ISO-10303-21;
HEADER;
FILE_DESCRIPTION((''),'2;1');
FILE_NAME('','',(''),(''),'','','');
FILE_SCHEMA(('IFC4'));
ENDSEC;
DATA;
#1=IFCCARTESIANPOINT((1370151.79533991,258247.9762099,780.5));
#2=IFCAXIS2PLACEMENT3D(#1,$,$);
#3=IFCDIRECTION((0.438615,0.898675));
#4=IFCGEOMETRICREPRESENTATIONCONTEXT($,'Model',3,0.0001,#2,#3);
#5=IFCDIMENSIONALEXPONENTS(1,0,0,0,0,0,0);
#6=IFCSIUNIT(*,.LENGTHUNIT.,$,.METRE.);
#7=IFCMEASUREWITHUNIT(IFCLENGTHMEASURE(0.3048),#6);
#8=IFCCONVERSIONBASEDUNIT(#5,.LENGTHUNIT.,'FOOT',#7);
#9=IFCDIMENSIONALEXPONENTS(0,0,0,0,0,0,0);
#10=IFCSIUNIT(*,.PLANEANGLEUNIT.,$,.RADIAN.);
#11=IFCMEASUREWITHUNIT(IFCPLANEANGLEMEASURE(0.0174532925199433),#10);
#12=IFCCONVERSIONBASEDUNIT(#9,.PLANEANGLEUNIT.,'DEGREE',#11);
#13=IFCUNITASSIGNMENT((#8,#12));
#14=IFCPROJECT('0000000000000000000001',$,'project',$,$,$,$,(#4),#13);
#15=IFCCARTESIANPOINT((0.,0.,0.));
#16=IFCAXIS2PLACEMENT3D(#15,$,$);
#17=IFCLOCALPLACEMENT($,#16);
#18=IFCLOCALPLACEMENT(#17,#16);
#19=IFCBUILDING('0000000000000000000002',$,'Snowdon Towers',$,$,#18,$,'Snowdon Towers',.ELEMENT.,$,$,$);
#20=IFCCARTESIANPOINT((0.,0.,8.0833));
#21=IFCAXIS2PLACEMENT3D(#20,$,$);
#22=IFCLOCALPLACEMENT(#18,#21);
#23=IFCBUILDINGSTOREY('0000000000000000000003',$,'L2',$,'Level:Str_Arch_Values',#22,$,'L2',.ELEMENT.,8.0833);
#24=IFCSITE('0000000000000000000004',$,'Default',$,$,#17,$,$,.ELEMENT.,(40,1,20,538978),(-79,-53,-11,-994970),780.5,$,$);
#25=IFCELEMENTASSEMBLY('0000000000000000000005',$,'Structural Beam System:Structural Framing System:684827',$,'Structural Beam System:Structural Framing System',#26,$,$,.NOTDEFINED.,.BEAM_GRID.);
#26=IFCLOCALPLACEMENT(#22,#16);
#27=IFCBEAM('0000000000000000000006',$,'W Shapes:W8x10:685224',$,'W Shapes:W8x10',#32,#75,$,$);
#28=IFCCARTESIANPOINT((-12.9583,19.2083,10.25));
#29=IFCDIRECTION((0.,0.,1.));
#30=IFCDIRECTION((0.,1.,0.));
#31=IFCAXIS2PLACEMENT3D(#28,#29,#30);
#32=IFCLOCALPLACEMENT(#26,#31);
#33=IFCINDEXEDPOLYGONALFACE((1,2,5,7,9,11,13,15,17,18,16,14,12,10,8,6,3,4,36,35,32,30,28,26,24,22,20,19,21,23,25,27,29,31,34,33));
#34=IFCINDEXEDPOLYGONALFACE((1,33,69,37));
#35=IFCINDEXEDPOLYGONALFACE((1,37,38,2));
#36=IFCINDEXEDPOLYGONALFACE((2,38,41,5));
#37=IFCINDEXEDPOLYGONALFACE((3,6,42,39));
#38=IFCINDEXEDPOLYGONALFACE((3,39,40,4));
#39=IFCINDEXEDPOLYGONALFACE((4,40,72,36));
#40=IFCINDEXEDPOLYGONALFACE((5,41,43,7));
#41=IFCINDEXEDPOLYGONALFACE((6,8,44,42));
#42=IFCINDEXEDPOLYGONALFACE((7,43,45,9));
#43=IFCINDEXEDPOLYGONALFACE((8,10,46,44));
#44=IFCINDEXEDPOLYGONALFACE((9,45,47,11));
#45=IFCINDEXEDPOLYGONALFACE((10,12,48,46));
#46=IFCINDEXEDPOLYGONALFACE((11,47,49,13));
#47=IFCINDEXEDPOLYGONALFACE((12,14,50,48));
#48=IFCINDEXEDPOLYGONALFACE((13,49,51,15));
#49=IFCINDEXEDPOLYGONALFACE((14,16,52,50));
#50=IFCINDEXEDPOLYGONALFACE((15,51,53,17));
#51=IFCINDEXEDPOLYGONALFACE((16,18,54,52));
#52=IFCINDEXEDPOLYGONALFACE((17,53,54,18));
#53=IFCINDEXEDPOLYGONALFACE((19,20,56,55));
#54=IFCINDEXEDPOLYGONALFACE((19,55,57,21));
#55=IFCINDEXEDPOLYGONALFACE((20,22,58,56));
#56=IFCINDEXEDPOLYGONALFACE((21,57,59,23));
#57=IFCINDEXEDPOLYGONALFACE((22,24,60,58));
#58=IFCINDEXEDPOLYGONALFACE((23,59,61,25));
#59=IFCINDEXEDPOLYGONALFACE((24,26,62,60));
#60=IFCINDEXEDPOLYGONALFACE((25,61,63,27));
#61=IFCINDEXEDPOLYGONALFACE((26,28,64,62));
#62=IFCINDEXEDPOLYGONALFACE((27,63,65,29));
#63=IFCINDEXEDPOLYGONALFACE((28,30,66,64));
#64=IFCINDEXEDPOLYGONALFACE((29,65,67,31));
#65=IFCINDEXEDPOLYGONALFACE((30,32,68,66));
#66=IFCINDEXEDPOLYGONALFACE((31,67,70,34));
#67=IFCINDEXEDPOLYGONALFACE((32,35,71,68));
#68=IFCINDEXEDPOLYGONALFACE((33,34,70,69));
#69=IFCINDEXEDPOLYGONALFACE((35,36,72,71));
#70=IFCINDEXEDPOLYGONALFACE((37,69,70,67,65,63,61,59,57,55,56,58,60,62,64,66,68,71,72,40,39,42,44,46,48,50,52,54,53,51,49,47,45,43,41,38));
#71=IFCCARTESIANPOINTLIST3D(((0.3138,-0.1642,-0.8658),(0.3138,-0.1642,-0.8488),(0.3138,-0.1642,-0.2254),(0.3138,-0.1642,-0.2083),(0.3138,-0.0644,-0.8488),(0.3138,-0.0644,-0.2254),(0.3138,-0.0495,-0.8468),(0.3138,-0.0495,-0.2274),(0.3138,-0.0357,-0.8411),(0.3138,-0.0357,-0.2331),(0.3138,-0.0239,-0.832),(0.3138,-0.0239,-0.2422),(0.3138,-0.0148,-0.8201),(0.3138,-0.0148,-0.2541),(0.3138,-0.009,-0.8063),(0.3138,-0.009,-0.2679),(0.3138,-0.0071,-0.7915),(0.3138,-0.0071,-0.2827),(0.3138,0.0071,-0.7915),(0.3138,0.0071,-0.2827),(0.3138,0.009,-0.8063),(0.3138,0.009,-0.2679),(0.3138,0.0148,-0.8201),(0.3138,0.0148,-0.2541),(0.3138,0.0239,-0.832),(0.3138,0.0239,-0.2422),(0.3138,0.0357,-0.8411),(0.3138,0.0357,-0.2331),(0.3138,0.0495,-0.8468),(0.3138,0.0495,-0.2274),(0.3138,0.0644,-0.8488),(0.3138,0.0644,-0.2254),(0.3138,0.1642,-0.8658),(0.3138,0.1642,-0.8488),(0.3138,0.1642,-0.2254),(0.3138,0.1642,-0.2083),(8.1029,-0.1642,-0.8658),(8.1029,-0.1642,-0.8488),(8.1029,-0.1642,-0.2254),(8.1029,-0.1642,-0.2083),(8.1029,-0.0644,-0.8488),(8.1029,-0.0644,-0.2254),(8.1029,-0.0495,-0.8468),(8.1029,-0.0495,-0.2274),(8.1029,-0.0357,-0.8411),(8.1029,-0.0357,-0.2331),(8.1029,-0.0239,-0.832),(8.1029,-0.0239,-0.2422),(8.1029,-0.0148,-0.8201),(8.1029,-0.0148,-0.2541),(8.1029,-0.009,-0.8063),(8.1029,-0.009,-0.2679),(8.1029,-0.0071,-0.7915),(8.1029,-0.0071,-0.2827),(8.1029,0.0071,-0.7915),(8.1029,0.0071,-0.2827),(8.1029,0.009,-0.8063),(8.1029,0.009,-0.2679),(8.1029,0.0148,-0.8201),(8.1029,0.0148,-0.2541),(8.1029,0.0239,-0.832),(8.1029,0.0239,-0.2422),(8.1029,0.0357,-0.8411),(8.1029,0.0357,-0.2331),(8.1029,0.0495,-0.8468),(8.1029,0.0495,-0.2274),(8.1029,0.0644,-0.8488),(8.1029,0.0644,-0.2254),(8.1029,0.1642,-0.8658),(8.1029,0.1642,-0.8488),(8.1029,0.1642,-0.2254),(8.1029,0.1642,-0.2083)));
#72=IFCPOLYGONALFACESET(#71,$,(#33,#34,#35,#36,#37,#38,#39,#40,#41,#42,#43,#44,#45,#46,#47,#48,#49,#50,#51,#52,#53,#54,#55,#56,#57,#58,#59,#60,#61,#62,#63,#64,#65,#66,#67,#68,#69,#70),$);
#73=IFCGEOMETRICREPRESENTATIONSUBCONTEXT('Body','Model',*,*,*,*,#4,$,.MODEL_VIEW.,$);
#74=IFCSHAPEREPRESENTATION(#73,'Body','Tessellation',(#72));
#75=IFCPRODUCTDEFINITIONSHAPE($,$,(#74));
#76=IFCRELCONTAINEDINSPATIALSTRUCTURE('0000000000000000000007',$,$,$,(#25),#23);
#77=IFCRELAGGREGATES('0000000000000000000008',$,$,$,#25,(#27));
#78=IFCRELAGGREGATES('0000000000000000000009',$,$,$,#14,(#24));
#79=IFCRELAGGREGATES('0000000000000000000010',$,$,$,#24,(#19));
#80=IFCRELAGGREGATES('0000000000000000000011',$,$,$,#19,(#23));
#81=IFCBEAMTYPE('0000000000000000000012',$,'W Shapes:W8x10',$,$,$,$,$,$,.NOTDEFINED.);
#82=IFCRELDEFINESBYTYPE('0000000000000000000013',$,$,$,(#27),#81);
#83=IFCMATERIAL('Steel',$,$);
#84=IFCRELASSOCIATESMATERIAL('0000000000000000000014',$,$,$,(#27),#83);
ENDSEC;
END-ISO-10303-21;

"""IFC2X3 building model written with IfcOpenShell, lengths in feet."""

from ifc_helpers import new_model, entity, si_unit, converted_unit, direction, frame, frame_2d, origin, place, context, subcontext, project, spatial, i_section, extrude, material, type_object, element, aggregate, save


model = new_model("IFC2X3")

# Units and contexts
model_context = context("Model", 3, precision=0.0001, world=frame((1370151.79533991, 258247.9762099, 780.5)), true_north=direction((0.438615, 0.898675)))
body_context = subcontext(model_context, "Body", "Model", "MODEL_VIEW")
ifc_project = project(units=[converted_unit("LENGTHUNIT", "FOOT", entity("IfcLengthMeasure", 0.3048), si_unit("LENGTHUNIT", "METRE"), dimensions=[1, 0, 0, 0, 0, 0, 0]), converted_unit("PLANEANGLEUNIT", "DEGREE", entity("IfcPlaneAngleMeasure", 0.0174532925199433), si_unit("PLANEANGLEUNIT", "RADIAN"), dimensions=[0, 0, 0, 0, 0, 0, 0])], contexts=[model_context])

# Site, building, storey
site_placement = place(None, origin())
site = spatial("IfcSite", under=ifc_project, at=site_placement, Name="Default", CompositionType="ELEMENT", RefLatitude=(40, 1, 20, 538978), RefLongitude=(-79, -53, -11, -994970), RefElevation=780.5)
building_placement = place(site_placement, origin())
building = spatial("IfcBuilding", under=site, at=building_placement, Name="Snowdon Towers", LongName="Snowdon Towers", CompositionType="ELEMENT")
storey_placement = place(building_placement, frame((0.0, 0.0, 8.0833)))
storey = spatial("IfcBuildingStorey", under=building, at=storey_placement, Name="L2", ObjectType="Level:Str_Arch_Values", LongName="L2", CompositionType="ELEMENT", Elevation=8.0833)

# Shared definitions
ifc_material_1 = material(Name="Steel")

# Element assembly, beam
assembly_placement = place(storey_placement, origin())
assembly = element("IfcElementAssembly", 1, at=assembly_placement, inside=storey, Name="Structural Beam System:Structural Framing System:684827", ObjectType="Structural Beam System:Structural Framing System", AssemblyPlace="NOTDEFINED", PredefinedType="BEAM_GRID")
beam_type_1 = type_object("IfcBeamType", Name="W Shapes:W8x10", PredefinedType="NOTDEFINED")
beam_1_placement = place(assembly_placement, frame((-12.9583, 19.2083, 10.25), z_axis=(0.0, 0.0, 1.0), x_axis=(0.0, 1.0, 0.0)))
beam_1 = element("IfcBeam", 2, at=beam_1_placement, type_object=beam_type_1, material=ifc_material_1, Name="W Shapes:W8x10:685224", ObjectType="W Shapes:W8x10", context=body_context, shape_type="SweptSolid", body=[
    extrude(i_section(OverallWidth=0.3283, OverallDepth=0.6575, WebThickness=0.0142, FlangeThickness=0.0171, FilletRadius=0.0573, at=frame_2d((0.0, 0.0), x_axis=(0.0, 1.0))), frame((0.3138, 0.0, -0.5371), z_axis=(1.0, 0.0, 0.0), x_axis=(0.0, 0.0, -1.0)), (0.0, 0.0, 1.0), 7.7892),
])
aggregate(assembly, [beam_1])

save(model, "model.ifc")
